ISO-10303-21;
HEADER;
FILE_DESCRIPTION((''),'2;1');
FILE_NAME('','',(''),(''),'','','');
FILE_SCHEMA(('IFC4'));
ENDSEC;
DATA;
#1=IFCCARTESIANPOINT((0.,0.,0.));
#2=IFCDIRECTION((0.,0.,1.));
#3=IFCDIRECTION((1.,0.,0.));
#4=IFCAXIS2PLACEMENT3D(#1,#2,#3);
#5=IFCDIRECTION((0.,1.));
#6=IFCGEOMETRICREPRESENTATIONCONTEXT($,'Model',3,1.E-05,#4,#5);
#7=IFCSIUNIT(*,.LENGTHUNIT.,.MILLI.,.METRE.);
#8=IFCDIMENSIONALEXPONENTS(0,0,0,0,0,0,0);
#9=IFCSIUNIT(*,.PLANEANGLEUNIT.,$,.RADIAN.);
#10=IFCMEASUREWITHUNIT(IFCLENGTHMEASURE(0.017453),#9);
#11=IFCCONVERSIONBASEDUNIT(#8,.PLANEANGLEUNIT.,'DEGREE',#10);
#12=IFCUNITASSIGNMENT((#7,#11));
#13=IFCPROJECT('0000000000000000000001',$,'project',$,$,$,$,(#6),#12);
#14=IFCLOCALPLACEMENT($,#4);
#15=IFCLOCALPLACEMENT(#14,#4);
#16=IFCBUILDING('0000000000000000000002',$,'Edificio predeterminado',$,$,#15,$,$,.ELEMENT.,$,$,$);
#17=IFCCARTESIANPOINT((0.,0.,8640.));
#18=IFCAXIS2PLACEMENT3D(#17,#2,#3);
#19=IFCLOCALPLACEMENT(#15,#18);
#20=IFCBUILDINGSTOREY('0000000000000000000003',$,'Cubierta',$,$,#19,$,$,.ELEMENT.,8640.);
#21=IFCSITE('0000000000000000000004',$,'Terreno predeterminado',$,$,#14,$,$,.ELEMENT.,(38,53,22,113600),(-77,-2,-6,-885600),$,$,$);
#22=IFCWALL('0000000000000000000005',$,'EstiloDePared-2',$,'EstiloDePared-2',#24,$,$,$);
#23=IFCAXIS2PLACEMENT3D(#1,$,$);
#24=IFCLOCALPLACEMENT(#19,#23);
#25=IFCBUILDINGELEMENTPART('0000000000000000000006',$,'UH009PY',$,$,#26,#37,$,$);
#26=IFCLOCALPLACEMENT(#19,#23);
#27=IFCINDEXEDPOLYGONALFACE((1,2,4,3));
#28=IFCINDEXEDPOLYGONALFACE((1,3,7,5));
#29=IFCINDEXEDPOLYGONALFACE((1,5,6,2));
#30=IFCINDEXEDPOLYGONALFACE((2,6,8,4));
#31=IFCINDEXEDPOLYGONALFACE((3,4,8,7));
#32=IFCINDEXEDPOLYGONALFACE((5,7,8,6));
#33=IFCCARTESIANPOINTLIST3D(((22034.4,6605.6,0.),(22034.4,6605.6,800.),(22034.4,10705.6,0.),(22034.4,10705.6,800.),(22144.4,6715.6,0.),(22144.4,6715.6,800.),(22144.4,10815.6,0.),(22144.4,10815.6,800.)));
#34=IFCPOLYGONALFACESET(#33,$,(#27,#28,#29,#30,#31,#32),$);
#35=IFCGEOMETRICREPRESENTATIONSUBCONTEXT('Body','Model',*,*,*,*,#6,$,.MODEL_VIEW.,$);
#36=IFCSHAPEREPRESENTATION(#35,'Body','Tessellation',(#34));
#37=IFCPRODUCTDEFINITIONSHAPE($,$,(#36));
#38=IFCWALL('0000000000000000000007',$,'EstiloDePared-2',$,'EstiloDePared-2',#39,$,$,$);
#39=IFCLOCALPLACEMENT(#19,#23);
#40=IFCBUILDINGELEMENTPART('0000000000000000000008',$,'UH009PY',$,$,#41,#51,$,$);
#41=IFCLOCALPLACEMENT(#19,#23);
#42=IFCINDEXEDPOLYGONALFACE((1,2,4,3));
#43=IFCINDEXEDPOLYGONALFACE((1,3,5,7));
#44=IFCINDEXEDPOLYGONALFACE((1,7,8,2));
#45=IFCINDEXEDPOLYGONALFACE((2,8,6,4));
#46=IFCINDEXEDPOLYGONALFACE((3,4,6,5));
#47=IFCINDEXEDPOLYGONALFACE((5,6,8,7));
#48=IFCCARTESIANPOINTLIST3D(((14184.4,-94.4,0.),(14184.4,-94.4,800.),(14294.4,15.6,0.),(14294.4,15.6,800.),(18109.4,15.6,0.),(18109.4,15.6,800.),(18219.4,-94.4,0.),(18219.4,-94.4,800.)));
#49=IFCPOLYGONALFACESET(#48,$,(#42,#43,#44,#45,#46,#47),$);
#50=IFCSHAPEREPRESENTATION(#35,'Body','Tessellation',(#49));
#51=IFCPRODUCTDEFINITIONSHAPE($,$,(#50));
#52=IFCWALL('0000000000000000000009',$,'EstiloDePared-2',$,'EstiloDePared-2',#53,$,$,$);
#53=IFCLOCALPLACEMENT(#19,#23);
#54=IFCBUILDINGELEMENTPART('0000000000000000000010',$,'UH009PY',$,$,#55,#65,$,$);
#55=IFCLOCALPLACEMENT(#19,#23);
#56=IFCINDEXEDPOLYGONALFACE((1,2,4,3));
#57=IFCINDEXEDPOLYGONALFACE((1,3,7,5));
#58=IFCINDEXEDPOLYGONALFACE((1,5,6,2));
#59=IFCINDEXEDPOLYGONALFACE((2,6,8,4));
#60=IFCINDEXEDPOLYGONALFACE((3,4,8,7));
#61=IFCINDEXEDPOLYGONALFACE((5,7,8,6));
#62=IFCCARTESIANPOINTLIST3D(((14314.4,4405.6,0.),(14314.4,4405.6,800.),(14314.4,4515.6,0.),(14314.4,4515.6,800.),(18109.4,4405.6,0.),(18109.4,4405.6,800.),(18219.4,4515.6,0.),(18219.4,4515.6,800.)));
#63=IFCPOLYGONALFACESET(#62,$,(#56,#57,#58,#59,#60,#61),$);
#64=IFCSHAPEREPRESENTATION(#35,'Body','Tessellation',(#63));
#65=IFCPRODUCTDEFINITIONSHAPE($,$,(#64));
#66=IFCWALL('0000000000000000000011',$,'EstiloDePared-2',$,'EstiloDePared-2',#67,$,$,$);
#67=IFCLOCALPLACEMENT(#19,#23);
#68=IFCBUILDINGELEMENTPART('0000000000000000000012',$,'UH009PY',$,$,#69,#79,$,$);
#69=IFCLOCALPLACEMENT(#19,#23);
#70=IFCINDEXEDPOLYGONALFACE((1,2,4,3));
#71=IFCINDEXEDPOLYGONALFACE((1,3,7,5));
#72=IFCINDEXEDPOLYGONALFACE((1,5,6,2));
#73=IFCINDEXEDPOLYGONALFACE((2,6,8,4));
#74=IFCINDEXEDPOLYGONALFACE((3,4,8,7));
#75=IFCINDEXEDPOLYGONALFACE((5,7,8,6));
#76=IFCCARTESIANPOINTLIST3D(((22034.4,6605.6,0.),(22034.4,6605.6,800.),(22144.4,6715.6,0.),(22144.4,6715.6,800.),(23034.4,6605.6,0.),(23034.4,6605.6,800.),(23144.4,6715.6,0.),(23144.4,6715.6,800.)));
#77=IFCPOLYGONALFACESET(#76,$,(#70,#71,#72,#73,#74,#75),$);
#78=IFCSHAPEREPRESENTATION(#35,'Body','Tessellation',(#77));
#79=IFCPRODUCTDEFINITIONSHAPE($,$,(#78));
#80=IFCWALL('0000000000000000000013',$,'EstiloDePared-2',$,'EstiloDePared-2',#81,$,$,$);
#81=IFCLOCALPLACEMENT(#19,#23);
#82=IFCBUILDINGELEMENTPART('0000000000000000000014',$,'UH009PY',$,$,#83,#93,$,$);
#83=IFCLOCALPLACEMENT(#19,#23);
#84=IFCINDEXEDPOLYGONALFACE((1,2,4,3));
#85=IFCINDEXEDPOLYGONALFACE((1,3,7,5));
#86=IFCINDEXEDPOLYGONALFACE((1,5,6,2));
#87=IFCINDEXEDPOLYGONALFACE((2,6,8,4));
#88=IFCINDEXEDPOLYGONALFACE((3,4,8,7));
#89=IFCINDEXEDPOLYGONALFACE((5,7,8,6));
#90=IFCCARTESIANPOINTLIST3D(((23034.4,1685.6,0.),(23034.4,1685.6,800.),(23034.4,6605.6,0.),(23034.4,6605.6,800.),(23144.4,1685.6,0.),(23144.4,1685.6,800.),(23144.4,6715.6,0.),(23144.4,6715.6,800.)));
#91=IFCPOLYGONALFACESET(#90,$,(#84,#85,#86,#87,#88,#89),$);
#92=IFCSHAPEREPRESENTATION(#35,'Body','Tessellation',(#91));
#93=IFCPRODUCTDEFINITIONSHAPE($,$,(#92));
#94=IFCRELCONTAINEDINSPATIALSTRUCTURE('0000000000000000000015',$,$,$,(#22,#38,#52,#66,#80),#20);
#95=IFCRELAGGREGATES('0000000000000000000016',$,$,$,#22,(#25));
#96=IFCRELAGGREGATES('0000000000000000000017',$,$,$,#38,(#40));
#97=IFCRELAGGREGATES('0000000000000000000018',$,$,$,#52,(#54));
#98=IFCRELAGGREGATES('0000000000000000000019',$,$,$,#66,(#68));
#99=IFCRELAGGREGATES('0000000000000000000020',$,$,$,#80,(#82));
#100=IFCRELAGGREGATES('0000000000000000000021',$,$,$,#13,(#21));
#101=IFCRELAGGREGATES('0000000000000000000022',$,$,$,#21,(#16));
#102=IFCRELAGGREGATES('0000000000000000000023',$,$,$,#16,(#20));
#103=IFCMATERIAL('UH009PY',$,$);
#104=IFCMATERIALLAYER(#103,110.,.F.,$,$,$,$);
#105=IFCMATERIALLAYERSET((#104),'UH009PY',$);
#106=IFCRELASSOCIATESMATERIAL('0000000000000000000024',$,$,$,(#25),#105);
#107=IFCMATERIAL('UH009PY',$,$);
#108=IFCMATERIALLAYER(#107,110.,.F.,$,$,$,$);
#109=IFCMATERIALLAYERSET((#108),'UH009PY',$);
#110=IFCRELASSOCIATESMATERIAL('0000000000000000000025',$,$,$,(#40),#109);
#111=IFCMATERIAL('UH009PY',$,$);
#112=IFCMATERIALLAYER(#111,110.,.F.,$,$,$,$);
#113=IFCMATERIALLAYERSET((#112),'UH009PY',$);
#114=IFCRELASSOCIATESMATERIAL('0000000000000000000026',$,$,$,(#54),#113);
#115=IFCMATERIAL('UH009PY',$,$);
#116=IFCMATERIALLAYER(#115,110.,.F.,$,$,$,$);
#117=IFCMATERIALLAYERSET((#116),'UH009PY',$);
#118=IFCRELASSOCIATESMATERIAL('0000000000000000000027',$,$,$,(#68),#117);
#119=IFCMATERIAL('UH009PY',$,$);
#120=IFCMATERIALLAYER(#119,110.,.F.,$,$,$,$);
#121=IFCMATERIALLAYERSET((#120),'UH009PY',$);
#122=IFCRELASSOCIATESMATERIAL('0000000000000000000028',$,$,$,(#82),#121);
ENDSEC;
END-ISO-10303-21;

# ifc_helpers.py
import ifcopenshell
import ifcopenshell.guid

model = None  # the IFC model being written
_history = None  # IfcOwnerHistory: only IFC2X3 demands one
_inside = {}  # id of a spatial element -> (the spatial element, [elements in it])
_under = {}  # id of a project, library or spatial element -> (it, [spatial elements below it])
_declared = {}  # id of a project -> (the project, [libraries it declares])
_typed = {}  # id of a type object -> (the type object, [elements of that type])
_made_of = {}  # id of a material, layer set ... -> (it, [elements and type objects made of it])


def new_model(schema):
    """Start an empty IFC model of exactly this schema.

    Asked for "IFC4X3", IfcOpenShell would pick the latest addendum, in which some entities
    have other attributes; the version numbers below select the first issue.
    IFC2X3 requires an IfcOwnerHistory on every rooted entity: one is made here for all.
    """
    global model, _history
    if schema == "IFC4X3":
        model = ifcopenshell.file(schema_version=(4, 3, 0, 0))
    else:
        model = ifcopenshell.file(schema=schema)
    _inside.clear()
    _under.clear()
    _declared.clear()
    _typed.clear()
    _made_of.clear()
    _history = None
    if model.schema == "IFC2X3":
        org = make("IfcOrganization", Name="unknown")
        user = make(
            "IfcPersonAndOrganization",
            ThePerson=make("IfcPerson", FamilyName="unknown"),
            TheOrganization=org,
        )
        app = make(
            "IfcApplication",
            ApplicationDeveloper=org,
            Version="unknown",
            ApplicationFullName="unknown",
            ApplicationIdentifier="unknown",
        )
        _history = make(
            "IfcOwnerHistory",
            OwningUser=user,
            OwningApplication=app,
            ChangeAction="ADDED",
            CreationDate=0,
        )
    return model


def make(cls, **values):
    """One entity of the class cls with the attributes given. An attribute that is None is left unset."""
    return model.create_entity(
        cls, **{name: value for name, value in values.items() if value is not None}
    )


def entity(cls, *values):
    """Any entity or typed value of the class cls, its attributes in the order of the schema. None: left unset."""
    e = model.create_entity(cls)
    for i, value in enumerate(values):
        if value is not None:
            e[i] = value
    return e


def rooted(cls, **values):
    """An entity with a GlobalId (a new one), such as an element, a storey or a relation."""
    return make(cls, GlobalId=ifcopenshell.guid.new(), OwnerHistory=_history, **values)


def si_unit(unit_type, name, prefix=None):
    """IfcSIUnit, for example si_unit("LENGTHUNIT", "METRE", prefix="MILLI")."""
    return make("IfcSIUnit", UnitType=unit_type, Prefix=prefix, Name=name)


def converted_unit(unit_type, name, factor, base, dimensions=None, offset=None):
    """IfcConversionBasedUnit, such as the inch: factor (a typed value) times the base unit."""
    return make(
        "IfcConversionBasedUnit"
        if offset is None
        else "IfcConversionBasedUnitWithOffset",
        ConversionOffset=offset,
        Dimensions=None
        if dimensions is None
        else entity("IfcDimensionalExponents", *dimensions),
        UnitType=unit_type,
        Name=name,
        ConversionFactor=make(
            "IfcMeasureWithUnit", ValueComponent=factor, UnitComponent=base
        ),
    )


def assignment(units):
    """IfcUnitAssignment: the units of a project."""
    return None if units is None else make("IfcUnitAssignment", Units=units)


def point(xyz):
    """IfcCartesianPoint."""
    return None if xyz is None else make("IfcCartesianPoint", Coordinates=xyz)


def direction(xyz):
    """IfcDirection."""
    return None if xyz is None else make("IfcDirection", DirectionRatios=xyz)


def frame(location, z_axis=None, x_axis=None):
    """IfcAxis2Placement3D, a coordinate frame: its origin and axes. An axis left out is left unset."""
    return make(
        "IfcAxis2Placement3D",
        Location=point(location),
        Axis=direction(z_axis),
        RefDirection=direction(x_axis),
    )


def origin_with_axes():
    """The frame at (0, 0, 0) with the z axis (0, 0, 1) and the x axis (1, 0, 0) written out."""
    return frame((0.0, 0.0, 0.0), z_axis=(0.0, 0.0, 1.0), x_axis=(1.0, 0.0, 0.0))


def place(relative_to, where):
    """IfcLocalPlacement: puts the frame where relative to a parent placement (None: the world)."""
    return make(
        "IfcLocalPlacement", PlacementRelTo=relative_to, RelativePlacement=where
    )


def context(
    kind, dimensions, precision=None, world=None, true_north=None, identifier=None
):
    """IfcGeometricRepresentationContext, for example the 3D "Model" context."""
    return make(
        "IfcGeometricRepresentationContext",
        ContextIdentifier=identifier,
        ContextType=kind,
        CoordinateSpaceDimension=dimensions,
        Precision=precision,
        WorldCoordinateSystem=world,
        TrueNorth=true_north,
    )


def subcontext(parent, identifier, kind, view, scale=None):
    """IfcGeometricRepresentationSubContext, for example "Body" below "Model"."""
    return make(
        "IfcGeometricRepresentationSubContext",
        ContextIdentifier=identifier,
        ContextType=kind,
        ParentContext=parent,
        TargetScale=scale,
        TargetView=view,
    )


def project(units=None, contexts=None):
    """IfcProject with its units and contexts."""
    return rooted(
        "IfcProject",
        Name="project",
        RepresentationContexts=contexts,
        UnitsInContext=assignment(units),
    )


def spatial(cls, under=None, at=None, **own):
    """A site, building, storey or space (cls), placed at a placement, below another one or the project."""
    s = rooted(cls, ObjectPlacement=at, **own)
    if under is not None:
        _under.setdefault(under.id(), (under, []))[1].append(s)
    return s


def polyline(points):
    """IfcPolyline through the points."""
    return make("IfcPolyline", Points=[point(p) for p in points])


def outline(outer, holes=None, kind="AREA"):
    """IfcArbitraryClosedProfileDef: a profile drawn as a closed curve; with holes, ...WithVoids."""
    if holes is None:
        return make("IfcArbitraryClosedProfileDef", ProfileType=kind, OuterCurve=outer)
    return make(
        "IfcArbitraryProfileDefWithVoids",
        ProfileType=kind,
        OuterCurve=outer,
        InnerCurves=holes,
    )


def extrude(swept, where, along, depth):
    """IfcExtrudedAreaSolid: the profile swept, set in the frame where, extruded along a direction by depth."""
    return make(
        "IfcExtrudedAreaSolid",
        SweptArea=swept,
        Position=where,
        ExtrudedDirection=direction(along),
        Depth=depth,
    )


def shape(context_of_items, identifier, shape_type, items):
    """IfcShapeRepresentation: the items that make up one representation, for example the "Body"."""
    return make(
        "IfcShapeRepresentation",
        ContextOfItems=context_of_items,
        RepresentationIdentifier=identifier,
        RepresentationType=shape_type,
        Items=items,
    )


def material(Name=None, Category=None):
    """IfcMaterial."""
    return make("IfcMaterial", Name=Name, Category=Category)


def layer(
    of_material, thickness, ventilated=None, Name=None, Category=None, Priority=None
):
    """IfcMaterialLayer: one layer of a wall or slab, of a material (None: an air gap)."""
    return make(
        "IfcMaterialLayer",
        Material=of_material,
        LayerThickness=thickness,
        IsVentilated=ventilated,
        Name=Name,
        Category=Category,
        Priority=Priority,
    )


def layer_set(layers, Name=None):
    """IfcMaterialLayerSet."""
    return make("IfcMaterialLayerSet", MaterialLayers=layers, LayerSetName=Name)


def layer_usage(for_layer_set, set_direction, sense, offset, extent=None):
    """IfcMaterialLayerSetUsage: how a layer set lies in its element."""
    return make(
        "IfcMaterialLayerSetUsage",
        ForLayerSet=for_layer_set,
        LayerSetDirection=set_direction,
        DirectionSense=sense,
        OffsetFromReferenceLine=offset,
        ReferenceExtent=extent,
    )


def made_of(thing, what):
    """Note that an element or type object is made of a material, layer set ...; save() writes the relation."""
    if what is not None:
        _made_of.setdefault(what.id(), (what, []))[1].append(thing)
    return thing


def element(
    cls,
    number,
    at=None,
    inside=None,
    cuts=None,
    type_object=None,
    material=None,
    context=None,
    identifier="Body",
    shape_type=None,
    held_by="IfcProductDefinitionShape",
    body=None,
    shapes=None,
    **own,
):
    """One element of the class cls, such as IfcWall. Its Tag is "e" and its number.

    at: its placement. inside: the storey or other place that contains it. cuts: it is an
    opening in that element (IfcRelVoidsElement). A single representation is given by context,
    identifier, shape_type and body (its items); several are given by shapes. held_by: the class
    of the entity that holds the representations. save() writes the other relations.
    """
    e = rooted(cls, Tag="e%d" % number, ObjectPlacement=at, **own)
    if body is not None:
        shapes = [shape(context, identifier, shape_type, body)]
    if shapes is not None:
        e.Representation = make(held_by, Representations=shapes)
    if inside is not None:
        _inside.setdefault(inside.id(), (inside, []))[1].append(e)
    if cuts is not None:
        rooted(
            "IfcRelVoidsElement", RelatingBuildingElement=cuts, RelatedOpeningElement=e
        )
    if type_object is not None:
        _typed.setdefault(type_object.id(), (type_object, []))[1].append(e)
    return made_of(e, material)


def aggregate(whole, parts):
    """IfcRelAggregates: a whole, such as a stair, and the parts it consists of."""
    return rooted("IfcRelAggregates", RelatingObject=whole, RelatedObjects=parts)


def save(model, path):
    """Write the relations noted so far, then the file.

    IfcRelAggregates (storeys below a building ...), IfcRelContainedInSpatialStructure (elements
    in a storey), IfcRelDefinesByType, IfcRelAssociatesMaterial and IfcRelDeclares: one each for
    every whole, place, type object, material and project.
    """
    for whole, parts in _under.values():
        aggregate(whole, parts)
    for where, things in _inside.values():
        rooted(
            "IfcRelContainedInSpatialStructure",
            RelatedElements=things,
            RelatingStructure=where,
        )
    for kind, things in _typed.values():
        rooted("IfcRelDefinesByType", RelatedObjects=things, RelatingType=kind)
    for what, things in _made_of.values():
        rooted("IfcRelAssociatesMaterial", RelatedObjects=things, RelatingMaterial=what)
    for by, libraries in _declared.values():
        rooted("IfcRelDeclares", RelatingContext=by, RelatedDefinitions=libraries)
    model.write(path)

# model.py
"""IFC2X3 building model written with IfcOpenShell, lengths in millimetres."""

from ifc_helpers import new_model, entity, si_unit, converted_unit, direction, frame, origin_with_axes, place, context, subcontext, project, spatial, polyline, outline, extrude, material, layer, layer_set, layer_usage, element, aggregate, save


model = new_model("IFC2X3")

# Units and contexts
model_context = context("Model", 3, precision=1e-05, world=origin_with_axes(), true_north=direction((0.0, 1.0)))
body_context = subcontext(model_context, "Body", "Model", "MODEL_VIEW")
ifc_project = project(units=[si_unit("LENGTHUNIT", "METRE", prefix="MILLI"), converted_unit("PLANEANGLEUNIT", "DEGREE", entity("IfcLengthMeasure", 0.017453), si_unit("PLANEANGLEUNIT", "RADIAN"), dimensions=[0, 0, 0, 0, 0, 0, 0])], contexts=[model_context])

# Site, building, storey
site_placement = place(None, origin_with_axes())
site = spatial("IfcSite", under=ifc_project, at=site_placement, Name="Terreno predeterminado", CompositionType="ELEMENT", RefLatitude=(38, 53, 22, 113600), RefLongitude=(-77, -2, -6, -885600))
building_placement = place(site_placement, origin_with_axes())
building = spatial("IfcBuilding", under=site, at=building_placement, Name="Edificio predeterminado", CompositionType="ELEMENT")
storey_placement = place(building_placement, frame((0.0, 0.0, 8640.0), z_axis=(0.0, 0.0, 1.0), x_axis=(1.0, 0.0, 0.0)))
storey = spatial("IfcBuildingStorey", under=building, at=storey_placement, Name="Cubierta", CompositionType="ELEMENT", Elevation=8640.0)

# Wall, building element part
wall_1_placement = place(storey_placement, frame((22089.4, 10760.6, 0.0), z_axis=(0.0, 0.0, 1.0), x_axis=(0.0, -1.0, 0.0)))
wall_1 = element("IfcWall", 1, at=wall_1_placement, inside=storey, Name="EstiloDePared-2", ObjectType="EstiloDePared-2")
ifc_material_1 = material(Name="UH009PY")
ifc_layer_1 = layer(ifc_material_1, 110.0, ventilated=False)
ifc_layer_set_1 = layer_set([ifc_layer_1], Name="UH009PY")
ifc_layer_usage_1 = layer_usage(ifc_layer_set_1, "AXIS2", "NEGATIVE", -55.0)
building_element_part_1_placement = place(wall_1_placement, origin_with_axes())
building_element_part_1 = element("IfcBuildingElementPart", 2, at=building_element_part_1_placement, material=ifc_layer_usage_1, Name="UH009PY", context=body_context, shape_type="SweptSolid", body=[
    extrude(outline(polyline([(4045.0, 55.0), (4155.0, -55.0), (55.0, -55.0), (-55.0, 55.0), (4045.0, 55.0)])), origin_with_axes(), (0.0, 0.0, 1.0), 800.0),
])
aggregate(wall_1, [building_element_part_1])

# Walls, building element parts
wall_2_placement = place(storey_placement, frame((18164.4, -39.4, 0.0), z_axis=(0.0, 0.0, 1.0), x_axis=(-1.0, 0.0, 0.0)))
wall_2 = element("IfcWall", 3, at=wall_2_placement, inside=storey, Name="EstiloDePared-2", ObjectType="EstiloDePared-2")
ifc_material_2 = material(Name="UH009PY")
ifc_layer_2 = layer(ifc_material_2, 110.0, ventilated=False)
ifc_layer_set_2 = layer_set([ifc_layer_2], Name="UH009PY")
ifc_layer_usage_2 = layer_usage(ifc_layer_set_2, "AXIS2", "NEGATIVE", -55.0)
building_element_part_2_placement = place(wall_2_placement, origin_with_axes())
building_element_part_2 = element("IfcBuildingElementPart", 4, at=building_element_part_2_placement, material=ifc_layer_usage_2, Name="UH009PY", context=body_context, shape_type="SweptSolid", body=[
    extrude(outline(polyline([(3980.0, 55.0), (3870.0, -55.0), (55.0, -55.0), (-55.0, 55.0), (3980.0, 55.0)])), origin_with_axes(), (0.0, 0.0, 1.0), 800.0),
])
aggregate(wall_2, [building_element_part_2])
wall_3_placement = place(storey_placement, frame((18164.4, 4460.6, 0.0), z_axis=(0.0, 0.0, 1.0), x_axis=(-1.0, 0.0, 0.0)))
wall_3 = element("IfcWall", 5, at=wall_3_placement, inside=storey, Name="EstiloDePared-2", ObjectType="EstiloDePared-2")
ifc_material_3 = material(Name="UH009PY")
ifc_layer_3 = layer(ifc_material_3, 110.0, ventilated=False)
ifc_layer_set_3 = layer_set([ifc_layer_3], Name="UH009PY")
ifc_layer_usage_3 = layer_usage(ifc_layer_set_3, "AXIS2", "NEGATIVE", -55.0)
building_element_part_3_placement = place(wall_3_placement, origin_with_axes())
building_element_part_3 = element("IfcBuildingElementPart", 6, at=building_element_part_3_placement, material=ifc_layer_usage_3, Name="UH009PY", context=body_context, shape_type="SweptSolid", body=[
    extrude(outline(polyline([(3850.0, 55.0), (3850.0, -55.0), (-55.0, -55.0), (55.0, 55.0), (3850.0, 55.0)])), origin_with_axes(), (0.0, 0.0, 1.0), 800.0),
])
aggregate(wall_3, [building_element_part_3])
wall_4_placement = place(storey_placement, frame((22089.4, 6660.6, 0.0), z_axis=(0.0, 0.0, 1.0), x_axis=(1.0, 0.0, 0.0)))
wall_4 = element("IfcWall", 7, at=wall_4_placement, inside=storey, Name="EstiloDePared-2", ObjectType="EstiloDePared-2")
ifc_material_4 = material(Name="UH009PY")
ifc_layer_4 = layer(ifc_material_4, 110.0, ventilated=False)
ifc_layer_set_4 = layer_set([ifc_layer_4], Name="UH009PY")
ifc_layer_usage_4 = layer_usage(ifc_layer_set_4, "AXIS2", "NEGATIVE", -55.0)
building_element_part_4_placement = place(wall_4_placement, origin_with_axes())
building_element_part_4 = element("IfcBuildingElementPart", 8, at=building_element_part_4_placement, material=ifc_layer_usage_4, Name="UH009PY", context=body_context, shape_type="SweptSolid", body=[
    extrude(outline(polyline([(1055.0, 55.0), (945.0, -55.0), (-55.0, -55.0), (55.0, 55.0), (1055.0, 55.0)])), origin_with_axes(), (0.0, 0.0, 1.0), 800.0),
])
aggregate(wall_4, [building_element_part_4])
wall_5_placement = place(storey_placement, frame((23089.4, 6660.6, 0.0), z_axis=(0.0, 0.0, 1.0), x_axis=(0.0, -1.0, 0.0)))
wall_5 = element("IfcWall", 9, at=wall_5_placement, inside=storey, Name="EstiloDePared-2", ObjectType="EstiloDePared-2")
ifc_material_5 = material(Name="UH009PY")
ifc_layer_5 = layer(ifc_material_5, 110.0, ventilated=False)
ifc_layer_set_5 = layer_set([ifc_layer_5], Name="UH009PY")
ifc_layer_usage_5 = layer_usage(ifc_layer_set_5, "AXIS2", "NEGATIVE", -55.0)
building_element_part_5_placement = place(wall_5_placement, origin_with_axes())
building_element_part_5 = element("IfcBuildingElementPart", 10, at=building_element_part_5_placement, material=ifc_layer_usage_5, Name="UH009PY", context=body_context, shape_type="SweptSolid", body=[
    extrude(outline(polyline([(4975.0, 55.0), (4975.0, -55.0), (55.0, -55.0), (-55.0, 55.0), (4975.0, 55.0)])), origin_with_axes(), (0.0, 0.0, 1.0), 800.0),
])
aggregate(wall_5, [building_element_part_5])

save(model, "model.ifc")
